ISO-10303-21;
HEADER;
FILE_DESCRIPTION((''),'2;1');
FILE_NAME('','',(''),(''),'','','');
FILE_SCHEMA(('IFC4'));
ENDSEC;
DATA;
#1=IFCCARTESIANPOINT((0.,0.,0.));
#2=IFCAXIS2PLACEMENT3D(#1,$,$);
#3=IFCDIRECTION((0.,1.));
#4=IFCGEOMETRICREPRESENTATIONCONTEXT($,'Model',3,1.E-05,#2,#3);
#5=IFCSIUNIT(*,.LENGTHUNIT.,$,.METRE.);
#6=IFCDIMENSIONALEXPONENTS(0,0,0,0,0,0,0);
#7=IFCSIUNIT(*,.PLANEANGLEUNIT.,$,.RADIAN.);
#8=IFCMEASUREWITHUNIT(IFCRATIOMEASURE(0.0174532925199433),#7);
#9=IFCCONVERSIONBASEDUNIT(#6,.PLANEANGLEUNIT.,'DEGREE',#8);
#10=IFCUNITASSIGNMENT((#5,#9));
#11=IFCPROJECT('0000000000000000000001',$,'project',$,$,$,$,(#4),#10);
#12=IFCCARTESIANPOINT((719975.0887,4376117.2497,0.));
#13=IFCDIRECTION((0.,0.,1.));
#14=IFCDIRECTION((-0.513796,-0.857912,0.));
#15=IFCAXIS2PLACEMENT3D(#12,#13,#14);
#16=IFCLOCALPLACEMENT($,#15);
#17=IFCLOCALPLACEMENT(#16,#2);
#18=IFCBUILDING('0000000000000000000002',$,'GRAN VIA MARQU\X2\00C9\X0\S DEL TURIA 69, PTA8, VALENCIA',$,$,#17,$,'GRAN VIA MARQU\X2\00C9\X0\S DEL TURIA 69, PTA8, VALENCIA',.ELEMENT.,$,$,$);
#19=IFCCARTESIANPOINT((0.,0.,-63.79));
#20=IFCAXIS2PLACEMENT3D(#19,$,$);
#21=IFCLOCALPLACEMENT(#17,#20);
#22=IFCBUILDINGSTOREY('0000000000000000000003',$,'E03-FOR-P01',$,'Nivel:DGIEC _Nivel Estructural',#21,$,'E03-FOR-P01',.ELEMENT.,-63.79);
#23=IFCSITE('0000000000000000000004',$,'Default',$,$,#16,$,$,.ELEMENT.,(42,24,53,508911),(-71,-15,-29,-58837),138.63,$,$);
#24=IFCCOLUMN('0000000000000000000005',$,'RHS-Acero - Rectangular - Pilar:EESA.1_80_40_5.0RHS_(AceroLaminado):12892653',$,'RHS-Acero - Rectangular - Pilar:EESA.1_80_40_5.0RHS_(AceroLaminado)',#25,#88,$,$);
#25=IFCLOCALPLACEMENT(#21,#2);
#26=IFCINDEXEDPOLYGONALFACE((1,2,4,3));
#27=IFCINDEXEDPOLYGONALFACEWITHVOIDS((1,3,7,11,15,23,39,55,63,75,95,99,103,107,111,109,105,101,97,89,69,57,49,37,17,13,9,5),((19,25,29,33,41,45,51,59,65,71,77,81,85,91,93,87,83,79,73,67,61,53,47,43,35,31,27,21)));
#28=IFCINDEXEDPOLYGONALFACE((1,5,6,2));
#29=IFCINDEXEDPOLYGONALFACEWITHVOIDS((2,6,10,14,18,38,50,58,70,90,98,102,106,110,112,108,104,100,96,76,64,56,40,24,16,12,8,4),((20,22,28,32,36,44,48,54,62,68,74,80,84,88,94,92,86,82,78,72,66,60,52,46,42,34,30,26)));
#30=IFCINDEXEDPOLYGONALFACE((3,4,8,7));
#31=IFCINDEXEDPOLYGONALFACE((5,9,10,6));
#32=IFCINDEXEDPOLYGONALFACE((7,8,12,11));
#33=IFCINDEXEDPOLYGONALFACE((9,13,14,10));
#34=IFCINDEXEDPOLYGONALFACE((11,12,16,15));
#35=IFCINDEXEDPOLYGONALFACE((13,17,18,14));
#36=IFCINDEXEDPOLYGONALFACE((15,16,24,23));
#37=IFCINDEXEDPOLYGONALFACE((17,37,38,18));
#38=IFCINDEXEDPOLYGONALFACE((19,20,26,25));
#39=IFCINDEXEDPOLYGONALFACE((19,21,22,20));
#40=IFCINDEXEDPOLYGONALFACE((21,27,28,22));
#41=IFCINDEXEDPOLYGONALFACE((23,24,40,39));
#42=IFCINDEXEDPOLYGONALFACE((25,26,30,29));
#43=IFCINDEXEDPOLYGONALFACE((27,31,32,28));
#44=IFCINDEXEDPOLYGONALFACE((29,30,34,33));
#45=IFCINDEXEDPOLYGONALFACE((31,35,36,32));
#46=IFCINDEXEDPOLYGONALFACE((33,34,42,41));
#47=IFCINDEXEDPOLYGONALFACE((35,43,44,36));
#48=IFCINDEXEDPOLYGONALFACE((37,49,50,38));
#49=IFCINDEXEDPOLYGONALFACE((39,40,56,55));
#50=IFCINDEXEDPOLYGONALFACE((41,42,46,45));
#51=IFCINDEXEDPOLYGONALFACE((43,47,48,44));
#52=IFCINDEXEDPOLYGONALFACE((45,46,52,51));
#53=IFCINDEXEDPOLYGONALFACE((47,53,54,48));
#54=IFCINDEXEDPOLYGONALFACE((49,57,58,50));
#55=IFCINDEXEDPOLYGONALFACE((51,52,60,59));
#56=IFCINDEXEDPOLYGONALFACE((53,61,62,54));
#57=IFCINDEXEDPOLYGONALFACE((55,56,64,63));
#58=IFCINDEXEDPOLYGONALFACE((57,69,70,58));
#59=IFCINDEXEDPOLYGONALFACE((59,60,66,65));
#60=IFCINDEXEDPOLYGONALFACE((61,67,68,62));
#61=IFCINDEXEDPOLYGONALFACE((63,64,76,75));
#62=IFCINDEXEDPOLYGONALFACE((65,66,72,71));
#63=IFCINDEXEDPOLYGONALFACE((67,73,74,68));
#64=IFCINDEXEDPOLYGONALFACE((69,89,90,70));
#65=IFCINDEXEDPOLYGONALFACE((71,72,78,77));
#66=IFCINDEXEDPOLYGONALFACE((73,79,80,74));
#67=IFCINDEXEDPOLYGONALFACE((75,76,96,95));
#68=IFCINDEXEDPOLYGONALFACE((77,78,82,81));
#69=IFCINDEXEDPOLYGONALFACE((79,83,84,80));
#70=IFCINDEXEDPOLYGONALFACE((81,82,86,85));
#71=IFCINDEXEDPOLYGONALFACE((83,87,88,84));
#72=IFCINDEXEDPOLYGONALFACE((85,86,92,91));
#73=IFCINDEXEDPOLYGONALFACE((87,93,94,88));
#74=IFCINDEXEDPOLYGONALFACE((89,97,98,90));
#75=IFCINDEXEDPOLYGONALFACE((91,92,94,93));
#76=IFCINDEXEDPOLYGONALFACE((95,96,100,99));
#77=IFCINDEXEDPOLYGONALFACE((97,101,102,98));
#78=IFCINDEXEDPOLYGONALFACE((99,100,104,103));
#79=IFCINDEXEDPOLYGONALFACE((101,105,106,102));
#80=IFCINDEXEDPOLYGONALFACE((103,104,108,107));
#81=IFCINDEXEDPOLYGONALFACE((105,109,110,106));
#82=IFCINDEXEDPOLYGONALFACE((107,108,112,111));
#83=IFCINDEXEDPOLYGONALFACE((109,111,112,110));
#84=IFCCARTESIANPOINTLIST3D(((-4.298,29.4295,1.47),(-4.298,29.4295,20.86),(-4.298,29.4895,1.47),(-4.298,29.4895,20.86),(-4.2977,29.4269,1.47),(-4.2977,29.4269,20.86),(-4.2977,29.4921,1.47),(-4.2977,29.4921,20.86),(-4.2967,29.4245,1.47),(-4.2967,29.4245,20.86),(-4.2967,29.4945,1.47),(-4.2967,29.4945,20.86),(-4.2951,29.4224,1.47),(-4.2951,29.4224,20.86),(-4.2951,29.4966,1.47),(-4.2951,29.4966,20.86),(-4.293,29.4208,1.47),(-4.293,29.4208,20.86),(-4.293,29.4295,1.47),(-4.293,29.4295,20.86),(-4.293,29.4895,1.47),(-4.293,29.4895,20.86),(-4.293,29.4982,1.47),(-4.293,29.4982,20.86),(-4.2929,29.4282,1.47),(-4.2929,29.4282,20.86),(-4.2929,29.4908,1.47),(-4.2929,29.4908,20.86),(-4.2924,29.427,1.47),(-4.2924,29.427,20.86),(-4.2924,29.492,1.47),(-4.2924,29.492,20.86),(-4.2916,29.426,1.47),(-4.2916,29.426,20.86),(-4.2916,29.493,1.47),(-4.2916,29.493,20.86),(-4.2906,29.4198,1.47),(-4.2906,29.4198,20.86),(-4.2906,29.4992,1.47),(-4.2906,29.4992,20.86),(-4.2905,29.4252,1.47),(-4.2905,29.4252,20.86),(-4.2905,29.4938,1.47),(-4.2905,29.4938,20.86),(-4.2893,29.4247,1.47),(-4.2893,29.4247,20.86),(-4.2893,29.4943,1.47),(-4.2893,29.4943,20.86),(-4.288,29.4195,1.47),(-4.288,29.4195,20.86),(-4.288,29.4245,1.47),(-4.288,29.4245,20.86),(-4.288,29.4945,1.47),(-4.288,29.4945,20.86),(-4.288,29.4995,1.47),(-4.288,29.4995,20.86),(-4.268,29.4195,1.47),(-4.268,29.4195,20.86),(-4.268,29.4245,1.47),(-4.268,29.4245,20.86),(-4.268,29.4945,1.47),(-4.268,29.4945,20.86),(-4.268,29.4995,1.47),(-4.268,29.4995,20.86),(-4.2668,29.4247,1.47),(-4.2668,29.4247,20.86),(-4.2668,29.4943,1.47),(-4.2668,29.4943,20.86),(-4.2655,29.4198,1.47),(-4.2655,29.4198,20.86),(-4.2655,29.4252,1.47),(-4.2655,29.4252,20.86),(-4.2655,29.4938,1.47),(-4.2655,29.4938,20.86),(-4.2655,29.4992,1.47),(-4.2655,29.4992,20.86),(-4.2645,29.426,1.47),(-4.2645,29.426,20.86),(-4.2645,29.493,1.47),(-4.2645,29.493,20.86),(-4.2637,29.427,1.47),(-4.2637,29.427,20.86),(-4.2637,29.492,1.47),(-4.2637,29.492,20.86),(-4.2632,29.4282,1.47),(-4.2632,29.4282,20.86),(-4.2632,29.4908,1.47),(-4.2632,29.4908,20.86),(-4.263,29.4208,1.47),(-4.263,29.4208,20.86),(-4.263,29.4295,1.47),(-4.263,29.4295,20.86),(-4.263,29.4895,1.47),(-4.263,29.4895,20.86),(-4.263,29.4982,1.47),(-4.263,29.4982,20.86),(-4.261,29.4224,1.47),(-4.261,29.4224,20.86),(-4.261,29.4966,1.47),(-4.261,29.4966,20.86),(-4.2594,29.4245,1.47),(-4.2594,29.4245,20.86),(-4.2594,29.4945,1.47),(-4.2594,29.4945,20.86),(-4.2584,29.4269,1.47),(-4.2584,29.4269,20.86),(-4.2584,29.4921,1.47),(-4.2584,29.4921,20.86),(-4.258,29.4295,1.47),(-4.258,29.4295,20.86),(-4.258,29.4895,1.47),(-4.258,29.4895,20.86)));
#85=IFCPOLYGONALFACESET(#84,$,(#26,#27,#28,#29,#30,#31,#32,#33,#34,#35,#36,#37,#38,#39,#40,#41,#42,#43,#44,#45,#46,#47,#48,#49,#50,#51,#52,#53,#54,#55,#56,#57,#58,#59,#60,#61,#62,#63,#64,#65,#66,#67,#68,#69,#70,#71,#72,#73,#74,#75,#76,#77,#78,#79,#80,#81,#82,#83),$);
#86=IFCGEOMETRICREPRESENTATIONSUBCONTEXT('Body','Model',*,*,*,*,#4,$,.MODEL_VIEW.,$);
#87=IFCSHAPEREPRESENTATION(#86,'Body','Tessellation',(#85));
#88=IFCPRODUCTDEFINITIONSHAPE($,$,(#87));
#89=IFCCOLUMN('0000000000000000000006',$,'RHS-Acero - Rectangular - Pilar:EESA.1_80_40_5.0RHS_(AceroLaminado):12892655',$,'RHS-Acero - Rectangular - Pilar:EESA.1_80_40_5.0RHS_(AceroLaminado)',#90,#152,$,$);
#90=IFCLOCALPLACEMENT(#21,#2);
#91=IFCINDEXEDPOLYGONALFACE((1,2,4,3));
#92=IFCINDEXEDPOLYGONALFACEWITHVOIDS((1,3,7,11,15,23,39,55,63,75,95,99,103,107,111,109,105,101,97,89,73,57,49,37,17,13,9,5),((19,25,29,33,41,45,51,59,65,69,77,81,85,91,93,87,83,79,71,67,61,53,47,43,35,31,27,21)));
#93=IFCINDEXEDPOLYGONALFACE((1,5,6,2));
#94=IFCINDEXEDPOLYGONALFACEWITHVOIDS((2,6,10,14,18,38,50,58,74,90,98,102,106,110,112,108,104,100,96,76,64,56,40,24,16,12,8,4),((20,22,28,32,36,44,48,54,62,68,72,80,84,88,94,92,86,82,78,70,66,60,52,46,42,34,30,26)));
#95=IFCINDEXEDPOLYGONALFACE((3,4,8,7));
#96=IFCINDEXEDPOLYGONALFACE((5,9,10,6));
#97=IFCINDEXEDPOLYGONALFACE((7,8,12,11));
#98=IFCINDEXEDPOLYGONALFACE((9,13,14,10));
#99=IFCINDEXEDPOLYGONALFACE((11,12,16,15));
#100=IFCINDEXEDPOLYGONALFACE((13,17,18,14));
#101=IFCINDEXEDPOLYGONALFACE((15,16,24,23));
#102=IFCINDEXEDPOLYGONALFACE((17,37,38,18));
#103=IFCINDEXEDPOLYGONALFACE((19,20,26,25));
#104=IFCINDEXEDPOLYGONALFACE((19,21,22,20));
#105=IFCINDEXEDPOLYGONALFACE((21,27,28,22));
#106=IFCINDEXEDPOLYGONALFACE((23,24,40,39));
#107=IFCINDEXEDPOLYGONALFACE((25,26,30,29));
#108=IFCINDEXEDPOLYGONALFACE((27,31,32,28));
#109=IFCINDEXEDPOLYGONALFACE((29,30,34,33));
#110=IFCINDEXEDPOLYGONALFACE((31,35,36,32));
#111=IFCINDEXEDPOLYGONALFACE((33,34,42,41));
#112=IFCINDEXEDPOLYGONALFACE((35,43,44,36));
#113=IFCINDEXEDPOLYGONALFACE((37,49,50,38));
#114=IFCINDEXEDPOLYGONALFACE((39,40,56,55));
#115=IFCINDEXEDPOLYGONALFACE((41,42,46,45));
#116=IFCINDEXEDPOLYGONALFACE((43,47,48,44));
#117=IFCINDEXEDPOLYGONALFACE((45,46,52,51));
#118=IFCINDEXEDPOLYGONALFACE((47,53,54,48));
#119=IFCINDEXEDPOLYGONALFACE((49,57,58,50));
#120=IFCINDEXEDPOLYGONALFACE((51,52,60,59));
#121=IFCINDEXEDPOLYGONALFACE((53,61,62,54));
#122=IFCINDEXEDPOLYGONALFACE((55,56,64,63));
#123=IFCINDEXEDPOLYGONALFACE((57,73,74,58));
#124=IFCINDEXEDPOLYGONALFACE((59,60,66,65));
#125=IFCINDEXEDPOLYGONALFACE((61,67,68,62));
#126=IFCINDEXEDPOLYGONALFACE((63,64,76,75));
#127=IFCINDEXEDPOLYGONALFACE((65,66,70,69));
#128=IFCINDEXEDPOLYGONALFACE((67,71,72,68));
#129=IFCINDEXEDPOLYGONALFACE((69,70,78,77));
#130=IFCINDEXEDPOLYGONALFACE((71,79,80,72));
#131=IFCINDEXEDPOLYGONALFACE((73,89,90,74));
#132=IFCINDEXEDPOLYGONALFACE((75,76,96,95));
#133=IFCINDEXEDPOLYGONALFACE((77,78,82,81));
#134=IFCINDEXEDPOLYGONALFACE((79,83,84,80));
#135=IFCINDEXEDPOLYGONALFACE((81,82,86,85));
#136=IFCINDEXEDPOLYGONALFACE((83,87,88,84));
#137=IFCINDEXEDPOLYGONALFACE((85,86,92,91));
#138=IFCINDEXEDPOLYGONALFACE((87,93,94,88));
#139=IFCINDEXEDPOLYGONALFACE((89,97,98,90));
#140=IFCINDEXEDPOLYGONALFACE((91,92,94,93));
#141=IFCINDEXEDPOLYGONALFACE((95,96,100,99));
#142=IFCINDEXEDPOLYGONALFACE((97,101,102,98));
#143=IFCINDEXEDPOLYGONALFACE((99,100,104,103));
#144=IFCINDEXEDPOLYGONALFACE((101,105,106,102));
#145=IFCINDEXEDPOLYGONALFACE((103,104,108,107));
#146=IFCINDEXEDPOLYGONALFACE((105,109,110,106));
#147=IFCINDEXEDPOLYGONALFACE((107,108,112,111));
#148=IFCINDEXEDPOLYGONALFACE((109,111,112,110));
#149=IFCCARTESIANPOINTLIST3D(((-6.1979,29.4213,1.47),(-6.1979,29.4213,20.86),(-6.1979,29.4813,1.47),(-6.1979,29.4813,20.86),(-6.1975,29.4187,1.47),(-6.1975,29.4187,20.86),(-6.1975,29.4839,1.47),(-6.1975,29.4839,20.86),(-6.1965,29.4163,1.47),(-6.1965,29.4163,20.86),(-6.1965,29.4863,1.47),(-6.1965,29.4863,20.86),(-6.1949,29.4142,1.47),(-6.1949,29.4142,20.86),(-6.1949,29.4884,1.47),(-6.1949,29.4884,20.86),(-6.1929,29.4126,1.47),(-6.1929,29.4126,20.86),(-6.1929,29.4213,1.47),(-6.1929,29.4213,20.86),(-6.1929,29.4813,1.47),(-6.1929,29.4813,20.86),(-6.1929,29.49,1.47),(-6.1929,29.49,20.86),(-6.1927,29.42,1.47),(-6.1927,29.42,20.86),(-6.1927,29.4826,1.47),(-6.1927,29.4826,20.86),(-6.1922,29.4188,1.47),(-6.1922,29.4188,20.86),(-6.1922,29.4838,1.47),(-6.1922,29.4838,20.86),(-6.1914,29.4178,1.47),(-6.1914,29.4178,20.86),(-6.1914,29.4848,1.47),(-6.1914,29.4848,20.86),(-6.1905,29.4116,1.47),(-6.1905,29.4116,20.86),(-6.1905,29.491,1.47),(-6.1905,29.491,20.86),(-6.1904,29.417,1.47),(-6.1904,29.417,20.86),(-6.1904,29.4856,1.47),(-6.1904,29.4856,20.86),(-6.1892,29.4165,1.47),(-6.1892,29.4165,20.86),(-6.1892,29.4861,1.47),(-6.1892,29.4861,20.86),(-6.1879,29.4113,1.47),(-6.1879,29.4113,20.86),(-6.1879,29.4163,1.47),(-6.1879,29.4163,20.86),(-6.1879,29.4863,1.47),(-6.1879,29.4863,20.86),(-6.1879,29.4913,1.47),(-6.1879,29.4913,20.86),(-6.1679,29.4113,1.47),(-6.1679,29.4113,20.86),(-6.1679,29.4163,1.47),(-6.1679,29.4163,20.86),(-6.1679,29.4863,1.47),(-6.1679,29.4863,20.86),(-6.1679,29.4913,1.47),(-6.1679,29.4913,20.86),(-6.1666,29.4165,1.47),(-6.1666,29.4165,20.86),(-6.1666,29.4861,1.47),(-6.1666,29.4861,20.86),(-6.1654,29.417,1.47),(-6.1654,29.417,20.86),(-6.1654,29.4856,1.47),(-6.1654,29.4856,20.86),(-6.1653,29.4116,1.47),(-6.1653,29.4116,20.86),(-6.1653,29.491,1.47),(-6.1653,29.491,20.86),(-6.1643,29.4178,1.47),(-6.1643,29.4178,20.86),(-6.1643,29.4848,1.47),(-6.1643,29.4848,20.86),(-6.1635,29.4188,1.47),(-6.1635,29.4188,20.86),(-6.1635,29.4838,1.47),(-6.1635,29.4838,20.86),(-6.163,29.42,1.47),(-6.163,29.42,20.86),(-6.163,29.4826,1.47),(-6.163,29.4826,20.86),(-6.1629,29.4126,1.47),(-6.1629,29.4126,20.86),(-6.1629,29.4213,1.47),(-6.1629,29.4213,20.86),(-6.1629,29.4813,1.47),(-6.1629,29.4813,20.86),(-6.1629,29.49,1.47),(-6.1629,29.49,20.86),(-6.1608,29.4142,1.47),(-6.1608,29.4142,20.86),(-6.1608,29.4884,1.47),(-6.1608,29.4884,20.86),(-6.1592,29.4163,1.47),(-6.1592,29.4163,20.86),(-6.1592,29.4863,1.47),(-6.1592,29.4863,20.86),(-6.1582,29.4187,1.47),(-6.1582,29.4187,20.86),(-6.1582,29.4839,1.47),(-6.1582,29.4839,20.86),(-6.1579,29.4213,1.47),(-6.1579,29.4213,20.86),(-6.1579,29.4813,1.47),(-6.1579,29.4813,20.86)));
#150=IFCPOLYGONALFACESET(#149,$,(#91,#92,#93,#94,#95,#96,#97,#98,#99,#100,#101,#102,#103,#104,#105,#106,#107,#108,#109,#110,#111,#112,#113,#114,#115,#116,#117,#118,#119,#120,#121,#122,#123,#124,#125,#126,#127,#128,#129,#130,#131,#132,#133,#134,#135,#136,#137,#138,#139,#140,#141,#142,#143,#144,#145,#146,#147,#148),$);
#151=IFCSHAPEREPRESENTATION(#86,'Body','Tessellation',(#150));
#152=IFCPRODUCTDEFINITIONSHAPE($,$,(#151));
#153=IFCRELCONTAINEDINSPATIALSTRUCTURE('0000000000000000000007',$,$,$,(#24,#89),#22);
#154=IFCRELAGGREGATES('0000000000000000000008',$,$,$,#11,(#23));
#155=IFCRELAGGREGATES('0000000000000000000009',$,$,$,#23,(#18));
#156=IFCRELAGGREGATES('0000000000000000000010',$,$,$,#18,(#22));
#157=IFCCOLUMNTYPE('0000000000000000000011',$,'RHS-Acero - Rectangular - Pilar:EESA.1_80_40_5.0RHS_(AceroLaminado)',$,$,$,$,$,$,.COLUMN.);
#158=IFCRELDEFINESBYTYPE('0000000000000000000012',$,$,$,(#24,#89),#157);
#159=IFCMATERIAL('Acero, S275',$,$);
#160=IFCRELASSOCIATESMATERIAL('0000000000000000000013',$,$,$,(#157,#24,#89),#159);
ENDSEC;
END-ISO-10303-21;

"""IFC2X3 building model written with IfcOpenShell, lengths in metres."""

from ifc_helpers import new_model, entity, si_unit, converted_unit, direction, frame, frame_2d, origin, place, context, subcontext, project, spatial, polyline, circle_curve, parameter, trimmed, segment, composite_curve, outline, extrude, source, transform, mapped, material, type_object, type_shapes, element, save


model = new_model("IFC2X3")

# Units and contexts
model_context = context("Model", 3, precision=1e-05, world=origin(), true_north=direction((0.0, 1.0)))
body_context = subcontext(model_context, "Body", "Model", "MODEL_VIEW")
ifc_project = project(units=[si_unit("LENGTHUNIT", "METRE"), converted_unit("PLANEANGLEUNIT", "DEGREE", entity("IfcRatioMeasure", 0.0174532925199433), si_unit("PLANEANGLEUNIT", "RADIAN"), dimensions=[0, 0, 0, 0, 0, 0, 0])], contexts=[model_context])

# Site, building, storey
site_placement = place(None, frame((719975.0887, 4376117.2497, 0.0), z_axis=(0.0, 0.0, 1.0), x_axis=(-0.513796, -0.857912, 0.0)))
site = spatial("IfcSite", under=ifc_project, at=site_placement, Name="Default", CompositionType="ELEMENT", RefLatitude=(42, 24, 53, 508911), RefLongitude=(-71, -15, -29, -58837), RefElevation=138.63)
building_placement = place(site_placement, origin())
building = spatial("IfcBuilding", under=site, at=building_placement, Name="GRAN VIA MARQUÉS DEL TURIA 69, PTA8, VALENCIA", LongName="GRAN VIA MARQUÉS DEL TURIA 69, PTA8, VALENCIA", CompositionType="ELEMENT")
storey_placement = place(building_placement, frame((0.0, 0.0, -63.79)))
storey = spatial("IfcBuildingStorey", under=building, at=storey_placement, Name="E03-FOR-P01", ObjectType="Nivel:DGIEC _Nivel Estructural", LongName="E03-FOR-P01", CompositionType="ELEMENT", Elevation=-63.79)

# Columns
ifc_material_1 = material(Name="Acero, S275")
column_type_1 = type_object("IfcColumnType", Name="RHS-Acero - Rectangular - Pilar:EESA.1_80_40_5.0RHS_(AceroLaminado)", PredefinedType="COLUMN", material=ifc_material_1)
shared_shape_1 = source(origin(), body_context, "Body", "SweptSolid", [
    extrude(outline(composite_curve([segment(polyline([(-0.01, -0.04), (0.01, -0.04)]), True, "CONTINUOUS"), segment(trimmed(circle_curve(frame_2d((0.01, -0.03), x_axis=(-1.0, 0.0)), 0.01), [parameter(90.0)], [parameter(180.0)], True, "PARAMETER"), True, "CONTINUOUS"), segment(polyline([(0.02, -0.03), (0.02, 0.03)]), True, "CONTINUOUS"), segment(trimmed(circle_curve(frame_2d((0.01, 0.03), x_axis=(-1.0, 0.0)), 0.01), [parameter(180.0)], [parameter(270.0)], True, "PARAMETER"), True, "CONTINUOUS"), segment(polyline([(0.01, 0.04), (-0.01, 0.04)]), True, "CONTINUOUS"), segment(trimmed(circle_curve(frame_2d((-0.01, 0.03), x_axis=(-1.0, 0.0)), 0.01), [parameter(270.0)], [parameter(360.0)], True, "PARAMETER"), True, "CONTINUOUS"), segment(polyline([(-0.02, 0.03), (-0.02, -0.03)]), True, "CONTINUOUS"), segment(trimmed(circle_curve(frame_2d((-0.01, -0.03), x_axis=(-1.0, 0.0)), 0.01), [parameter(360.0)], [parameter(90.0)], True, "PARAMETER"), True, "CONTINUOUS")], self_intersect=False), holes=[composite_curve([segment(trimmed(circle_curve(frame_2d((-0.01, -0.03), x_axis=(-1.0, 0.0)), 0.005), [parameter(0.0)], [parameter(90.0)], True, "PARAMETER"), False, "CONTINUOUS"), segment(polyline([(-0.015, -0.03), (-0.015, 0.03)]), True, "CONTINUOUS"), segment(trimmed(circle_curve(frame_2d((-0.01, 0.03), x_axis=(-1.0, 0.0)), 0.005), [parameter(270.0)], [parameter(0.0)], True, "PARAMETER"), False, "CONTINUOUS"), segment(polyline([(-0.01, 0.035), (0.01, 0.035)]), True, "CONTINUOUS"), segment(trimmed(circle_curve(frame_2d((0.01, 0.03), x_axis=(-1.0, 0.0)), 0.005), [parameter(180.0)], [parameter(270.0)], True, "PARAMETER"), False, "CONTINUOUS"), segment(polyline([(0.015, 0.03), (0.015, -0.03)]), True, "CONTINUOUS"), segment(trimmed(circle_curve(frame_2d((0.01, -0.03), x_axis=(-1.0, 0.0)), 0.005), [parameter(90.0)], [parameter(180.0)], True, "PARAMETER"), False, "CONTINUOUS"), segment(polyline([(0.01, -0.035), (-0.01, -0.035)]), True, "CONTINUOUS")], self_intersect=False)]), frame((0.0, 0.0, -62.32), z_axis=(0.0, 0.0, 1.0), x_axis=(-1.0, 0.0, 0.0)), (0.0, 0.0, 1.0), 19.39),
])
type_shapes(column_type_1, [shared_shape_1])
for number, where, z_axis, x_axis, name in (
    (1, (-4.278, 29.4595, 63.79), (0.0, 0.0, 1.0), (-1.0, 0.0, 0.0), "RHS-Acero - Rectangular - Pilar:EESA.1_80_40_5.0RHS_(AceroLaminado):12892653"),
    (2, (-6.1779, 29.4513, 63.79), (0.0, 0.0, 1.0), (-1.0, 0.0, 0.0), "RHS-Acero - Rectangular - Pilar:EESA.1_80_40_5.0RHS_(AceroLaminado):12892655"),
):
    element("IfcColumn", number, at=place(storey_placement, frame(where, z_axis=z_axis, x_axis=x_axis)), inside=storey, type_object=column_type_1, material=ifc_material_1, Name=name, ObjectType="RHS-Acero - Rectangular - Pilar:EESA.1_80_40_5.0RHS_(AceroLaminado)", context=body_context, shape_type="MappedRepresentation", body=[
        mapped(shared_shape_1, transform((0.0, 0.0, 0.0), scale=1.0)),
    ])

save(model, "model.ifc")
